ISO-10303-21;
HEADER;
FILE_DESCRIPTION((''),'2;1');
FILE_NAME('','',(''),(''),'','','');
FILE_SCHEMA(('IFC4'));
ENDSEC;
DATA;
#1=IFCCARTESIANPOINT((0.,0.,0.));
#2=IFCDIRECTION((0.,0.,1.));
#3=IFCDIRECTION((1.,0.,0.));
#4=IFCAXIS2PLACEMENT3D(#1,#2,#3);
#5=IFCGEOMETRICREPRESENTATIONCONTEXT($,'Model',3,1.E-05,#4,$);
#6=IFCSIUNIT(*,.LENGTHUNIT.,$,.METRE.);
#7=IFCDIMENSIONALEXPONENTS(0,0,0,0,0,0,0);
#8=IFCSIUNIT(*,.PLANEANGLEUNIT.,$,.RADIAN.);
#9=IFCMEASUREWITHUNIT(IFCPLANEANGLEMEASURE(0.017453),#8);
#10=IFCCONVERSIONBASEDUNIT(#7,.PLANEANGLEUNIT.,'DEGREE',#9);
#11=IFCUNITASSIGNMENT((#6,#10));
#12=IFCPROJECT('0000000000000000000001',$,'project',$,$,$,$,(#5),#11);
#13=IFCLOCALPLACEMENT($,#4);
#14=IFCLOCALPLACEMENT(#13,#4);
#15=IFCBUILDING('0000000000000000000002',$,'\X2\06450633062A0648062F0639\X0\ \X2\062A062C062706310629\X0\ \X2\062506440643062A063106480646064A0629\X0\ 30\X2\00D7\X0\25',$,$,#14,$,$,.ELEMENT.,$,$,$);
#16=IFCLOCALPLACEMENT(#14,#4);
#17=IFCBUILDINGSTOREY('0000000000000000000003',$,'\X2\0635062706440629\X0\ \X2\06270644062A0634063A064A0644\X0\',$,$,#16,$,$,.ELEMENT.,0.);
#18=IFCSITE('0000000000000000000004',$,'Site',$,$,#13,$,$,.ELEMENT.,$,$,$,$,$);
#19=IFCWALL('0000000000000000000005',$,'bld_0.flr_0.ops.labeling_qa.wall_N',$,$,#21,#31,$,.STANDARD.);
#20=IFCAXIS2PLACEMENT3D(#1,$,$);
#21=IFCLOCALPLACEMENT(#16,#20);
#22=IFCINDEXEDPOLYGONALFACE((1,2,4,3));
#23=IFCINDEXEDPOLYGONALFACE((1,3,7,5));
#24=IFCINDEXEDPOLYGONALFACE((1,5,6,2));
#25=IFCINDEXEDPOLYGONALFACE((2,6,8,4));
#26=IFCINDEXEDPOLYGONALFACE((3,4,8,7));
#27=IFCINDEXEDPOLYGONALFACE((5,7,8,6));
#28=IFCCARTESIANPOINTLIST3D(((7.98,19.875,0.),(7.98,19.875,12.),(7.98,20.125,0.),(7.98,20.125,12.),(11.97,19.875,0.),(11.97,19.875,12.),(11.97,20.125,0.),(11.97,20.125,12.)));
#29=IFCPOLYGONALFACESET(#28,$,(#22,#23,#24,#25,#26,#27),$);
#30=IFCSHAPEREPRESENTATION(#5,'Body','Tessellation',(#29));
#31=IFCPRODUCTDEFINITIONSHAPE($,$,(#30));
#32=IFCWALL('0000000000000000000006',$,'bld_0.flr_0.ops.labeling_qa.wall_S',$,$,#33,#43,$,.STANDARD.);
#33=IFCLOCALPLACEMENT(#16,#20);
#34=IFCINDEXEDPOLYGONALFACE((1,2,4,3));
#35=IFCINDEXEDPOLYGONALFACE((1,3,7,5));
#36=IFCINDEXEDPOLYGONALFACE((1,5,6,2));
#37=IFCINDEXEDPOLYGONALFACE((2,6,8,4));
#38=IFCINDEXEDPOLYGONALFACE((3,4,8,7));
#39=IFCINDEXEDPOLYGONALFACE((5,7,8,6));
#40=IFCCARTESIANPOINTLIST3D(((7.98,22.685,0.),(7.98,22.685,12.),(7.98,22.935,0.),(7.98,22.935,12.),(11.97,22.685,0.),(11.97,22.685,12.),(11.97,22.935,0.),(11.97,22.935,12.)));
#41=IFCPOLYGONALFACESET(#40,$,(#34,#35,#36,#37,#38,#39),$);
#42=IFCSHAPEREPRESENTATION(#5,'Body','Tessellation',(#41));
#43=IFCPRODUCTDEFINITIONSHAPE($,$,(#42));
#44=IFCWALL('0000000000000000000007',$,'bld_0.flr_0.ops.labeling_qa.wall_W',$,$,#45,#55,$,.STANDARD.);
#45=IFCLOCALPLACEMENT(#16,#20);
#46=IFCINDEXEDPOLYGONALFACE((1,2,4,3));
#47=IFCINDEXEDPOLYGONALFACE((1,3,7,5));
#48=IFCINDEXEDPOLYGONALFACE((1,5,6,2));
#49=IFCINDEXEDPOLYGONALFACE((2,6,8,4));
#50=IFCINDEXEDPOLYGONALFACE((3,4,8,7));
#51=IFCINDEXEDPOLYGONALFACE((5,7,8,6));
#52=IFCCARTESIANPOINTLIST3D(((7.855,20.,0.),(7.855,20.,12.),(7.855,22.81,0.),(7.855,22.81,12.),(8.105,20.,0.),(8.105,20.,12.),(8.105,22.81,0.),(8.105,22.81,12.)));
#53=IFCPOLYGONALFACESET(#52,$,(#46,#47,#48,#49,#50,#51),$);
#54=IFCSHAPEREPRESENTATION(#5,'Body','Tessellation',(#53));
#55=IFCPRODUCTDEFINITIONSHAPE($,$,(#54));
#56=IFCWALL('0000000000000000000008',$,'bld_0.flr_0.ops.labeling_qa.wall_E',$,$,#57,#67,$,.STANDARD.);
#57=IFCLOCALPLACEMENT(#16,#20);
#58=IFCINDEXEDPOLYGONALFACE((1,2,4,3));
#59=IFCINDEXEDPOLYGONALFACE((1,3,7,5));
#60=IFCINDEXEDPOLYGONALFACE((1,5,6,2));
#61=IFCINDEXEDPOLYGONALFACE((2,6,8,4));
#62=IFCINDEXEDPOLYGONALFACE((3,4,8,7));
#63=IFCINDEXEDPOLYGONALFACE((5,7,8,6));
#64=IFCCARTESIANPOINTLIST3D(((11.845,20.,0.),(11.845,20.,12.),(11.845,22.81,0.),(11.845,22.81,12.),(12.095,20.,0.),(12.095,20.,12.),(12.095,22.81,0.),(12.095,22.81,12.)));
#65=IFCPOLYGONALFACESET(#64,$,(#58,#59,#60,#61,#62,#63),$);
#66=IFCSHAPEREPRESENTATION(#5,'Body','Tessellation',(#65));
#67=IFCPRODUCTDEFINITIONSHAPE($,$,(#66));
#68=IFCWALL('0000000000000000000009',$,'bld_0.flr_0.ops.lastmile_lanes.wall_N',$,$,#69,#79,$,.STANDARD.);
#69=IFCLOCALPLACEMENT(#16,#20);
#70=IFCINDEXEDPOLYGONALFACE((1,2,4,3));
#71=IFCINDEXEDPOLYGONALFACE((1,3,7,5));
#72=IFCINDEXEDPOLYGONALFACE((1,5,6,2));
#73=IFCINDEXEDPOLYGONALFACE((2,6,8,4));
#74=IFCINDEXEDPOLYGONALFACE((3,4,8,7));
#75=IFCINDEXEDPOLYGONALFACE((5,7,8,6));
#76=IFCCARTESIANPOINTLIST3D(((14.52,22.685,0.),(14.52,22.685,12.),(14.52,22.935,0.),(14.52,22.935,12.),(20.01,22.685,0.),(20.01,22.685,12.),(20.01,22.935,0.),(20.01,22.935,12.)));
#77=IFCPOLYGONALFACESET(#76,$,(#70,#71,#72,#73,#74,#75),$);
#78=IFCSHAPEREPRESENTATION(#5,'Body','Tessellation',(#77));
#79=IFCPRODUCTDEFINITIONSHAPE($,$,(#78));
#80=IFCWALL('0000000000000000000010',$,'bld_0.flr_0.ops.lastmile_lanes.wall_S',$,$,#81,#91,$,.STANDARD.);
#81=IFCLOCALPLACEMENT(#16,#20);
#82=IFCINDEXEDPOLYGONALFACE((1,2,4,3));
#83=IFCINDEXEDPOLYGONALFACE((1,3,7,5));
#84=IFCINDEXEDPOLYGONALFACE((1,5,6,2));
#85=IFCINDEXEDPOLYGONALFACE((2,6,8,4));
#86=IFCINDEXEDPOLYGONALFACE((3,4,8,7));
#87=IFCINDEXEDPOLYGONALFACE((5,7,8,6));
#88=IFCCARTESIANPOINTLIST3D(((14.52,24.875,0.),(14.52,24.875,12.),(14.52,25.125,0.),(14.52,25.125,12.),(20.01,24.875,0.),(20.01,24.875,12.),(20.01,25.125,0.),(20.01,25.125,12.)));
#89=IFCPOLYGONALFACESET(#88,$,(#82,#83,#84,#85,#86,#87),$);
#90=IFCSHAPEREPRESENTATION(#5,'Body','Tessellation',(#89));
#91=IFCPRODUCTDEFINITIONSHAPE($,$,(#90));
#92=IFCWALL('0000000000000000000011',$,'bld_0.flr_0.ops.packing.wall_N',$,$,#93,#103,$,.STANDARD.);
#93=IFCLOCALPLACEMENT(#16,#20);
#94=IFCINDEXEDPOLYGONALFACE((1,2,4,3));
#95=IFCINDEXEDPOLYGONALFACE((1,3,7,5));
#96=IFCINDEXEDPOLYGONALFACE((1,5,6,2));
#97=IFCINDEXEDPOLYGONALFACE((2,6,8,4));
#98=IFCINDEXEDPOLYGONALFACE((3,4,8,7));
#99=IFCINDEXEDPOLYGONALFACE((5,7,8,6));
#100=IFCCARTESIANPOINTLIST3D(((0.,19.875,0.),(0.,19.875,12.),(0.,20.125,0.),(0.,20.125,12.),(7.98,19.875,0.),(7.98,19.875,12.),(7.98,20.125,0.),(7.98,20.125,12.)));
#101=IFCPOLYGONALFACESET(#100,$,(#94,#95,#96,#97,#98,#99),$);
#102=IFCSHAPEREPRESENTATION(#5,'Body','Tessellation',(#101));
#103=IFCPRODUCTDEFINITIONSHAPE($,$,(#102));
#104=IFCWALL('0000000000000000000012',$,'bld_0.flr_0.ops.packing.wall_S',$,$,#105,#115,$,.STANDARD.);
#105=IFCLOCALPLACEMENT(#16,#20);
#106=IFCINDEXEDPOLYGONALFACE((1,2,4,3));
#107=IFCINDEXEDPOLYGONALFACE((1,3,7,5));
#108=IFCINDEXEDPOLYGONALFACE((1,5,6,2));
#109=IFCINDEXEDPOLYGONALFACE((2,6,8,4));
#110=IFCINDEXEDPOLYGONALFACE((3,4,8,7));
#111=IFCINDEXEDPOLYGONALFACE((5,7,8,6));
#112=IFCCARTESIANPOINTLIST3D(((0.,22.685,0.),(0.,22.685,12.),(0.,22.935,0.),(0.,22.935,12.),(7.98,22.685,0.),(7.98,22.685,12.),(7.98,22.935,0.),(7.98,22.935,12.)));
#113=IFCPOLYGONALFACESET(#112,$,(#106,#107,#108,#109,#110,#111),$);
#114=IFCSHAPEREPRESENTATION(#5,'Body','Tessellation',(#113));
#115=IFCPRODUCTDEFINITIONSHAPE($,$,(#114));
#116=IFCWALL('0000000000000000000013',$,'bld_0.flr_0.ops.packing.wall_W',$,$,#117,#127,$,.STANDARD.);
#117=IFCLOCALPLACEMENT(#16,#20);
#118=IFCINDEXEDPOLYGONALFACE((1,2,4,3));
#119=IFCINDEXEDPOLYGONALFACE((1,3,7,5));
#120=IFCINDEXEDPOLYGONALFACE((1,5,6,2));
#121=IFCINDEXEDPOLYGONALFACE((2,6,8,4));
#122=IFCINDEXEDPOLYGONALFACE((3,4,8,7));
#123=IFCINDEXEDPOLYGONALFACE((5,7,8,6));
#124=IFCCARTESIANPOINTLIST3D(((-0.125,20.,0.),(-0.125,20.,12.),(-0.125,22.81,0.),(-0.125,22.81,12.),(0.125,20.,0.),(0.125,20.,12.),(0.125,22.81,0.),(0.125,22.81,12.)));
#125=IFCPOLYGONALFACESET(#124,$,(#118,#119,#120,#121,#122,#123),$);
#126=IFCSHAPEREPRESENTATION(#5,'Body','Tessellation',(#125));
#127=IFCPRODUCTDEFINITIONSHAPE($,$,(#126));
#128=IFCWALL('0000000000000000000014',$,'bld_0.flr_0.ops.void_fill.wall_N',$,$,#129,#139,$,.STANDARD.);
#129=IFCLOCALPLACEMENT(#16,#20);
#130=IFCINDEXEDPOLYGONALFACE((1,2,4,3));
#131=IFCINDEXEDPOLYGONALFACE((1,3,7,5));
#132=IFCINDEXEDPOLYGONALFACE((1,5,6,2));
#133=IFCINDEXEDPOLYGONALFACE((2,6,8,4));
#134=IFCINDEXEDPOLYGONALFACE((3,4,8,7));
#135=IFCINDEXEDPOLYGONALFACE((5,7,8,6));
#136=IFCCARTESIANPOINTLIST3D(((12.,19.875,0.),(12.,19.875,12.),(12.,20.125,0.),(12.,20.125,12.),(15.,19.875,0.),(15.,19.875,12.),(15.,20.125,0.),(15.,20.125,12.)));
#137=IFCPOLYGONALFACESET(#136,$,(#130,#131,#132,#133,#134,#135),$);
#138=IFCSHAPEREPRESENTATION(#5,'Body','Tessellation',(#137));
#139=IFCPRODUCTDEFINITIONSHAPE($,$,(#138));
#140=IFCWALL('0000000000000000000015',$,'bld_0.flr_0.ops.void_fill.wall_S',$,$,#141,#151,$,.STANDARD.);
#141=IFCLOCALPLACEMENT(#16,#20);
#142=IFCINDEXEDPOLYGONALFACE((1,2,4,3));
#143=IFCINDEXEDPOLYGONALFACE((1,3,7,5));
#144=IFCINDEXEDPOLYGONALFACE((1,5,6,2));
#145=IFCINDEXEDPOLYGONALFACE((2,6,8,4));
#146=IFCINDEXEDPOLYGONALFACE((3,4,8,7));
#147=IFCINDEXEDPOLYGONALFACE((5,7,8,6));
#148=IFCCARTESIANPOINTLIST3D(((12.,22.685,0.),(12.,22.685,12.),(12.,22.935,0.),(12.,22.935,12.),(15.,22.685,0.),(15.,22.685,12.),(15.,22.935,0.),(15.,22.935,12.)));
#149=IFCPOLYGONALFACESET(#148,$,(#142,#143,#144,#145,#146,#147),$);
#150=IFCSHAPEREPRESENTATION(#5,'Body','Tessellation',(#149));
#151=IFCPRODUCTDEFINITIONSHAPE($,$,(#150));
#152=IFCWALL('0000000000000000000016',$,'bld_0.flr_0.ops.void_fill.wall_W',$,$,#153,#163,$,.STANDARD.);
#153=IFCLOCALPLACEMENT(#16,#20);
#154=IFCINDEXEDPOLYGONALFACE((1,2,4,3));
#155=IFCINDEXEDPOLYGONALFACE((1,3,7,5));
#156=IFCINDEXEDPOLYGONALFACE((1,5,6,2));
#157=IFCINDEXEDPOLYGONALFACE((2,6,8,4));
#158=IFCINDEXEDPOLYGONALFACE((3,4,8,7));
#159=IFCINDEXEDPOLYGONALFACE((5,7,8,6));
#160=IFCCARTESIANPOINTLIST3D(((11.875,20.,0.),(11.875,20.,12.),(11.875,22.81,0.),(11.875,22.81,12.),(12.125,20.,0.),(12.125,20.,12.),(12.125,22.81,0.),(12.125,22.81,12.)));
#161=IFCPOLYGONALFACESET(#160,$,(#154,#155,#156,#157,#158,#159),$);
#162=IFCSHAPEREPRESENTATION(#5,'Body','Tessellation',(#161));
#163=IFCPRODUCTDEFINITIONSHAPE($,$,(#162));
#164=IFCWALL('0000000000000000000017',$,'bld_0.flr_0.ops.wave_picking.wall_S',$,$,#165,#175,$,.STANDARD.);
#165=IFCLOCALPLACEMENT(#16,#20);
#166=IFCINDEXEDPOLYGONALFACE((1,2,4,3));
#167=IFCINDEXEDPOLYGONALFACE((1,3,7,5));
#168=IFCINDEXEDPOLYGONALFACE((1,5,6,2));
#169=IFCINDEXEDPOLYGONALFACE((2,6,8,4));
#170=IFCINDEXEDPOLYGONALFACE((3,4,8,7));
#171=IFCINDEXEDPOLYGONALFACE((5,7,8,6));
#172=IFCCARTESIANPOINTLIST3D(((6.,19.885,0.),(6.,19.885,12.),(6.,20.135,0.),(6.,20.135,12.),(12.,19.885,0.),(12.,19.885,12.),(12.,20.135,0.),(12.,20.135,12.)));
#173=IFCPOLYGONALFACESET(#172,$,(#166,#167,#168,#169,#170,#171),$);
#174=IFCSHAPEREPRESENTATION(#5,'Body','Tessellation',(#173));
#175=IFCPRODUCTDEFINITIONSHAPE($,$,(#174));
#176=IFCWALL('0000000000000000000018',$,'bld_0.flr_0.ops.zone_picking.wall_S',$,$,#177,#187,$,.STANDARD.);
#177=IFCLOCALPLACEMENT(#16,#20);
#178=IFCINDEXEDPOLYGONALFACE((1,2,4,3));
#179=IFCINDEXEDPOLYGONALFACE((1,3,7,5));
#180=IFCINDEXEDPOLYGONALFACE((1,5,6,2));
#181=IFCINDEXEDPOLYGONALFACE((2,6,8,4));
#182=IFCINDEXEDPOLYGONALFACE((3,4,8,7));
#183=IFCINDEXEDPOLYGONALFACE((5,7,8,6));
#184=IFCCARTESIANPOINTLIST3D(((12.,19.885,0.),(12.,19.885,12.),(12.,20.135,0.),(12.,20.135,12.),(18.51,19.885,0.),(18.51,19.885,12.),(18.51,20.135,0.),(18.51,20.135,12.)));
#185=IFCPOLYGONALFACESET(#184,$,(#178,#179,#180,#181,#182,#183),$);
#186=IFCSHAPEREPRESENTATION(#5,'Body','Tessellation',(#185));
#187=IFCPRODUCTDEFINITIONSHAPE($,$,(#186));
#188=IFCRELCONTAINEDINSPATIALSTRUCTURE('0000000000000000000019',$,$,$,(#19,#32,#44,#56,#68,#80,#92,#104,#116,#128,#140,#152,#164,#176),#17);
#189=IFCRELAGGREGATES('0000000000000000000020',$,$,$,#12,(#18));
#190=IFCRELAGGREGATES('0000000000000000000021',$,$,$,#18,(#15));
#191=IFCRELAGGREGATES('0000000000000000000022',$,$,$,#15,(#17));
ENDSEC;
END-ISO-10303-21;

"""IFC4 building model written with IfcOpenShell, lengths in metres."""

from ifc_helpers import new_model, entity, si_unit, converted_unit, frame, frame_2d, origin_with_axes, place, context, project, spatial, rectangle, extrude, element, save


model = new_model("IFC4")

# Units and contexts
model_context = context("Model", 3, precision=1e-05, world=origin_with_axes())
ifc_project = project(units=[si_unit("LENGTHUNIT", "METRE"), converted_unit("PLANEANGLEUNIT", "DEGREE", entity("IfcPlaneAngleMeasure", 0.017453), si_unit("PLANEANGLEUNIT", "RADIAN"), dimensions=[0, 0, 0, 0, 0, 0, 0])], contexts=[model_context])

# Site, building, storey
site_placement = place(None, origin_with_axes())
site = spatial("IfcSite", under=ifc_project, at=site_placement, Name="Site", CompositionType="ELEMENT")
building_placement = place(site_placement, origin_with_axes())
building = spatial("IfcBuilding", under=site, at=building_placement, Name="مستودع تجارة إلكترونية 30×25", CompositionType="ELEMENT")
storey_placement = place(building_placement, origin_with_axes())
storey = spatial("IfcBuildingStorey", under=building, at=storey_placement, Name="صالة التشغيل", CompositionType="ELEMENT", Elevation=0.0)

# Walls
for number, where, z_axis, x_axis, name in (
    (1, (7.98, 20.0, 0.0), (0.0, 0.0, 1.0), (1.0, 0.0, 0.0), "bld_0.flr_0.ops.labeling_qa.wall_N"),
    (2, (7.98, 22.81, 0.0), (0.0, 0.0, 1.0), (1.0, 0.0, 0.0), "bld_0.flr_0.ops.labeling_qa.wall_S"),
):
    element("IfcWall", number, at=place(storey_placement, frame(where, z_axis=z_axis, x_axis=x_axis)), inside=storey, Name=name, PredefinedType="STANDARD", context=model_context, shape_type="SweptSolid", body=[
        extrude(rectangle(XDim=3.99, YDim=0.25, at=frame_2d((1.995, 0.0), x_axis=(1.0, 0.0))), origin_with_axes(), (0.0, 0.0, 1.0), 12.0),
    ])
for number, where, z_axis, x_axis, name in (
    (3, (7.98, 20.0, 0.0), (0.0, 0.0, 1.0), (0.0, 1.0, 0.0), "bld_0.flr_0.ops.labeling_qa.wall_W"),
    (4, (11.97, 20.0, 0.0), (0.0, 0.0, 1.0), (0.0, 1.0, 0.0), "bld_0.flr_0.ops.labeling_qa.wall_E"),
):
    element("IfcWall", number, at=place(storey_placement, frame(where, z_axis=z_axis, x_axis=x_axis)), inside=storey, Name=name, PredefinedType="STANDARD", context=model_context, shape_type="SweptSolid", body=[
        extrude(rectangle(XDim=2.81, YDim=0.25, at=frame_2d((1.405, 0.0), x_axis=(1.0, 0.0))), origin_with_axes(), (0.0, 0.0, 1.0), 12.0),
    ])
for number, where, z_axis, x_axis, name in (
    (5, (14.52, 22.81, 0.0), (0.0, 0.0, 1.0), (1.0, 0.0, 0.0), "bld_0.flr_0.ops.lastmile_lanes.wall_N"),
    (6, (14.52, 25.0, 0.0), (0.0, 0.0, 1.0), (1.0, 0.0, 0.0), "bld_0.flr_0.ops.lastmile_lanes.wall_S"),
):
    element("IfcWall", number, at=place(storey_placement, frame(where, z_axis=z_axis, x_axis=x_axis)), inside=storey, Name=name, PredefinedType="STANDARD", context=model_context, shape_type="SweptSolid", body=[
        extrude(rectangle(XDim=5.49, YDim=0.25, at=frame_2d((2.745, 0.0), x_axis=(1.0, 0.0))), origin_with_axes(), (0.0, 0.0, 1.0), 12.0),
    ])
for number, where, z_axis, x_axis, name in (
    (7, (0.0, 20.0, 0.0), (0.0, 0.0, 1.0), (1.0, 0.0, 0.0), "bld_0.flr_0.ops.packing.wall_N"),
    (8, (0.0, 22.81, 0.0), (0.0, 0.0, 1.0), (1.0, 0.0, 0.0), "bld_0.flr_0.ops.packing.wall_S"),
):
    element("IfcWall", number, at=place(storey_placement, frame(where, z_axis=z_axis, x_axis=x_axis)), inside=storey, Name=name, PredefinedType="STANDARD", context=model_context, shape_type="SweptSolid", body=[
        extrude(rectangle(XDim=7.98, YDim=0.25, at=frame_2d((3.99, 0.0), x_axis=(1.0, 0.0))), origin_with_axes(), (0.0, 0.0, 1.0), 12.0),
    ])
for number, where, z_axis, x_axis, name in (
    (9, (0.0, 20.0, 0.0), (0.0, 0.0, 1.0), (0.0, 1.0, 0.0), "bld_0.flr_0.ops.packing.wall_W"),
):
    element("IfcWall", number, at=place(storey_placement, frame(where, z_axis=z_axis, x_axis=x_axis)), inside=storey, Name=name, PredefinedType="STANDARD", context=model_context, shape_type="SweptSolid", body=[
        extrude(rectangle(XDim=2.81, YDim=0.25, at=frame_2d((1.405, 0.0), x_axis=(1.0, 0.0))), origin_with_axes(), (0.0, 0.0, 1.0), 12.0),
    ])
for number, where, z_axis, x_axis, name in (
    (10, (12.0, 20.0, 0.0), (0.0, 0.0, 1.0), (1.0, 0.0, 0.0), "bld_0.flr_0.ops.void_fill.wall_N"),
    (11, (12.0, 22.81, 0.0), (0.0, 0.0, 1.0), (1.0, 0.0, 0.0), "bld_0.flr_0.ops.void_fill.wall_S"),
):
    element("IfcWall", number, at=place(storey_placement, frame(where, z_axis=z_axis, x_axis=x_axis)), inside=storey, Name=name, PredefinedType="STANDARD", context=model_context, shape_type="SweptSolid", body=[
        extrude(rectangle(XDim=3.0, YDim=0.25, at=frame_2d((1.5, 0.0), x_axis=(1.0, 0.0))), origin_with_axes(), (0.0, 0.0, 1.0), 12.0),
    ])
for number, where, z_axis, x_axis, name in (
    (12, (12.0, 20.0, 0.0), (0.0, 0.0, 1.0), (0.0, 1.0, 0.0), "bld_0.flr_0.ops.void_fill.wall_W"),
):
    element("IfcWall", number, at=place(storey_placement, frame(where, z_axis=z_axis, x_axis=x_axis)), inside=storey, Name=name, PredefinedType="STANDARD", context=model_context, shape_type="SweptSolid", body=[
        extrude(rectangle(XDim=2.81, YDim=0.25, at=frame_2d((1.405, 0.0), x_axis=(1.0, 0.0))), origin_with_axes(), (0.0, 0.0, 1.0), 12.0),
    ])
wall_1_placement = place(storey_placement, frame((6.0, 20.01, 0.0), z_axis=(0.0, 0.0, 1.0), x_axis=(1.0, 0.0, 0.0)))
element("IfcWall", 13, at=wall_1_placement, inside=storey, Name="bld_0.flr_0.ops.wave_picking.wall_S", PredefinedType="STANDARD", context=model_context, shape_type="SweptSolid", body=[
    extrude(rectangle(XDim=6.0, YDim=0.25, at=frame_2d((3.0, 0.0), x_axis=(1.0, 0.0))), origin_with_axes(), (0.0, 0.0, 1.0), 12.0),
])
wall_2_placement = place(storey_placement, frame((12.0, 20.01, 0.0), z_axis=(0.0, 0.0, 1.0), x_axis=(1.0, 0.0, 0.0)))
element("IfcWall", 14, at=wall_2_placement, inside=storey, Name="bld_0.flr_0.ops.zone_picking.wall_S", PredefinedType="STANDARD", context=model_context, shape_type="SweptSolid", body=[
    extrude(rectangle(XDim=6.51, YDim=0.25, at=frame_2d((3.255, 0.0), x_axis=(1.0, 0.0))), origin_with_axes(), (0.0, 0.0, 1.0), 12.0),
])

save(model, "model.ifc")
